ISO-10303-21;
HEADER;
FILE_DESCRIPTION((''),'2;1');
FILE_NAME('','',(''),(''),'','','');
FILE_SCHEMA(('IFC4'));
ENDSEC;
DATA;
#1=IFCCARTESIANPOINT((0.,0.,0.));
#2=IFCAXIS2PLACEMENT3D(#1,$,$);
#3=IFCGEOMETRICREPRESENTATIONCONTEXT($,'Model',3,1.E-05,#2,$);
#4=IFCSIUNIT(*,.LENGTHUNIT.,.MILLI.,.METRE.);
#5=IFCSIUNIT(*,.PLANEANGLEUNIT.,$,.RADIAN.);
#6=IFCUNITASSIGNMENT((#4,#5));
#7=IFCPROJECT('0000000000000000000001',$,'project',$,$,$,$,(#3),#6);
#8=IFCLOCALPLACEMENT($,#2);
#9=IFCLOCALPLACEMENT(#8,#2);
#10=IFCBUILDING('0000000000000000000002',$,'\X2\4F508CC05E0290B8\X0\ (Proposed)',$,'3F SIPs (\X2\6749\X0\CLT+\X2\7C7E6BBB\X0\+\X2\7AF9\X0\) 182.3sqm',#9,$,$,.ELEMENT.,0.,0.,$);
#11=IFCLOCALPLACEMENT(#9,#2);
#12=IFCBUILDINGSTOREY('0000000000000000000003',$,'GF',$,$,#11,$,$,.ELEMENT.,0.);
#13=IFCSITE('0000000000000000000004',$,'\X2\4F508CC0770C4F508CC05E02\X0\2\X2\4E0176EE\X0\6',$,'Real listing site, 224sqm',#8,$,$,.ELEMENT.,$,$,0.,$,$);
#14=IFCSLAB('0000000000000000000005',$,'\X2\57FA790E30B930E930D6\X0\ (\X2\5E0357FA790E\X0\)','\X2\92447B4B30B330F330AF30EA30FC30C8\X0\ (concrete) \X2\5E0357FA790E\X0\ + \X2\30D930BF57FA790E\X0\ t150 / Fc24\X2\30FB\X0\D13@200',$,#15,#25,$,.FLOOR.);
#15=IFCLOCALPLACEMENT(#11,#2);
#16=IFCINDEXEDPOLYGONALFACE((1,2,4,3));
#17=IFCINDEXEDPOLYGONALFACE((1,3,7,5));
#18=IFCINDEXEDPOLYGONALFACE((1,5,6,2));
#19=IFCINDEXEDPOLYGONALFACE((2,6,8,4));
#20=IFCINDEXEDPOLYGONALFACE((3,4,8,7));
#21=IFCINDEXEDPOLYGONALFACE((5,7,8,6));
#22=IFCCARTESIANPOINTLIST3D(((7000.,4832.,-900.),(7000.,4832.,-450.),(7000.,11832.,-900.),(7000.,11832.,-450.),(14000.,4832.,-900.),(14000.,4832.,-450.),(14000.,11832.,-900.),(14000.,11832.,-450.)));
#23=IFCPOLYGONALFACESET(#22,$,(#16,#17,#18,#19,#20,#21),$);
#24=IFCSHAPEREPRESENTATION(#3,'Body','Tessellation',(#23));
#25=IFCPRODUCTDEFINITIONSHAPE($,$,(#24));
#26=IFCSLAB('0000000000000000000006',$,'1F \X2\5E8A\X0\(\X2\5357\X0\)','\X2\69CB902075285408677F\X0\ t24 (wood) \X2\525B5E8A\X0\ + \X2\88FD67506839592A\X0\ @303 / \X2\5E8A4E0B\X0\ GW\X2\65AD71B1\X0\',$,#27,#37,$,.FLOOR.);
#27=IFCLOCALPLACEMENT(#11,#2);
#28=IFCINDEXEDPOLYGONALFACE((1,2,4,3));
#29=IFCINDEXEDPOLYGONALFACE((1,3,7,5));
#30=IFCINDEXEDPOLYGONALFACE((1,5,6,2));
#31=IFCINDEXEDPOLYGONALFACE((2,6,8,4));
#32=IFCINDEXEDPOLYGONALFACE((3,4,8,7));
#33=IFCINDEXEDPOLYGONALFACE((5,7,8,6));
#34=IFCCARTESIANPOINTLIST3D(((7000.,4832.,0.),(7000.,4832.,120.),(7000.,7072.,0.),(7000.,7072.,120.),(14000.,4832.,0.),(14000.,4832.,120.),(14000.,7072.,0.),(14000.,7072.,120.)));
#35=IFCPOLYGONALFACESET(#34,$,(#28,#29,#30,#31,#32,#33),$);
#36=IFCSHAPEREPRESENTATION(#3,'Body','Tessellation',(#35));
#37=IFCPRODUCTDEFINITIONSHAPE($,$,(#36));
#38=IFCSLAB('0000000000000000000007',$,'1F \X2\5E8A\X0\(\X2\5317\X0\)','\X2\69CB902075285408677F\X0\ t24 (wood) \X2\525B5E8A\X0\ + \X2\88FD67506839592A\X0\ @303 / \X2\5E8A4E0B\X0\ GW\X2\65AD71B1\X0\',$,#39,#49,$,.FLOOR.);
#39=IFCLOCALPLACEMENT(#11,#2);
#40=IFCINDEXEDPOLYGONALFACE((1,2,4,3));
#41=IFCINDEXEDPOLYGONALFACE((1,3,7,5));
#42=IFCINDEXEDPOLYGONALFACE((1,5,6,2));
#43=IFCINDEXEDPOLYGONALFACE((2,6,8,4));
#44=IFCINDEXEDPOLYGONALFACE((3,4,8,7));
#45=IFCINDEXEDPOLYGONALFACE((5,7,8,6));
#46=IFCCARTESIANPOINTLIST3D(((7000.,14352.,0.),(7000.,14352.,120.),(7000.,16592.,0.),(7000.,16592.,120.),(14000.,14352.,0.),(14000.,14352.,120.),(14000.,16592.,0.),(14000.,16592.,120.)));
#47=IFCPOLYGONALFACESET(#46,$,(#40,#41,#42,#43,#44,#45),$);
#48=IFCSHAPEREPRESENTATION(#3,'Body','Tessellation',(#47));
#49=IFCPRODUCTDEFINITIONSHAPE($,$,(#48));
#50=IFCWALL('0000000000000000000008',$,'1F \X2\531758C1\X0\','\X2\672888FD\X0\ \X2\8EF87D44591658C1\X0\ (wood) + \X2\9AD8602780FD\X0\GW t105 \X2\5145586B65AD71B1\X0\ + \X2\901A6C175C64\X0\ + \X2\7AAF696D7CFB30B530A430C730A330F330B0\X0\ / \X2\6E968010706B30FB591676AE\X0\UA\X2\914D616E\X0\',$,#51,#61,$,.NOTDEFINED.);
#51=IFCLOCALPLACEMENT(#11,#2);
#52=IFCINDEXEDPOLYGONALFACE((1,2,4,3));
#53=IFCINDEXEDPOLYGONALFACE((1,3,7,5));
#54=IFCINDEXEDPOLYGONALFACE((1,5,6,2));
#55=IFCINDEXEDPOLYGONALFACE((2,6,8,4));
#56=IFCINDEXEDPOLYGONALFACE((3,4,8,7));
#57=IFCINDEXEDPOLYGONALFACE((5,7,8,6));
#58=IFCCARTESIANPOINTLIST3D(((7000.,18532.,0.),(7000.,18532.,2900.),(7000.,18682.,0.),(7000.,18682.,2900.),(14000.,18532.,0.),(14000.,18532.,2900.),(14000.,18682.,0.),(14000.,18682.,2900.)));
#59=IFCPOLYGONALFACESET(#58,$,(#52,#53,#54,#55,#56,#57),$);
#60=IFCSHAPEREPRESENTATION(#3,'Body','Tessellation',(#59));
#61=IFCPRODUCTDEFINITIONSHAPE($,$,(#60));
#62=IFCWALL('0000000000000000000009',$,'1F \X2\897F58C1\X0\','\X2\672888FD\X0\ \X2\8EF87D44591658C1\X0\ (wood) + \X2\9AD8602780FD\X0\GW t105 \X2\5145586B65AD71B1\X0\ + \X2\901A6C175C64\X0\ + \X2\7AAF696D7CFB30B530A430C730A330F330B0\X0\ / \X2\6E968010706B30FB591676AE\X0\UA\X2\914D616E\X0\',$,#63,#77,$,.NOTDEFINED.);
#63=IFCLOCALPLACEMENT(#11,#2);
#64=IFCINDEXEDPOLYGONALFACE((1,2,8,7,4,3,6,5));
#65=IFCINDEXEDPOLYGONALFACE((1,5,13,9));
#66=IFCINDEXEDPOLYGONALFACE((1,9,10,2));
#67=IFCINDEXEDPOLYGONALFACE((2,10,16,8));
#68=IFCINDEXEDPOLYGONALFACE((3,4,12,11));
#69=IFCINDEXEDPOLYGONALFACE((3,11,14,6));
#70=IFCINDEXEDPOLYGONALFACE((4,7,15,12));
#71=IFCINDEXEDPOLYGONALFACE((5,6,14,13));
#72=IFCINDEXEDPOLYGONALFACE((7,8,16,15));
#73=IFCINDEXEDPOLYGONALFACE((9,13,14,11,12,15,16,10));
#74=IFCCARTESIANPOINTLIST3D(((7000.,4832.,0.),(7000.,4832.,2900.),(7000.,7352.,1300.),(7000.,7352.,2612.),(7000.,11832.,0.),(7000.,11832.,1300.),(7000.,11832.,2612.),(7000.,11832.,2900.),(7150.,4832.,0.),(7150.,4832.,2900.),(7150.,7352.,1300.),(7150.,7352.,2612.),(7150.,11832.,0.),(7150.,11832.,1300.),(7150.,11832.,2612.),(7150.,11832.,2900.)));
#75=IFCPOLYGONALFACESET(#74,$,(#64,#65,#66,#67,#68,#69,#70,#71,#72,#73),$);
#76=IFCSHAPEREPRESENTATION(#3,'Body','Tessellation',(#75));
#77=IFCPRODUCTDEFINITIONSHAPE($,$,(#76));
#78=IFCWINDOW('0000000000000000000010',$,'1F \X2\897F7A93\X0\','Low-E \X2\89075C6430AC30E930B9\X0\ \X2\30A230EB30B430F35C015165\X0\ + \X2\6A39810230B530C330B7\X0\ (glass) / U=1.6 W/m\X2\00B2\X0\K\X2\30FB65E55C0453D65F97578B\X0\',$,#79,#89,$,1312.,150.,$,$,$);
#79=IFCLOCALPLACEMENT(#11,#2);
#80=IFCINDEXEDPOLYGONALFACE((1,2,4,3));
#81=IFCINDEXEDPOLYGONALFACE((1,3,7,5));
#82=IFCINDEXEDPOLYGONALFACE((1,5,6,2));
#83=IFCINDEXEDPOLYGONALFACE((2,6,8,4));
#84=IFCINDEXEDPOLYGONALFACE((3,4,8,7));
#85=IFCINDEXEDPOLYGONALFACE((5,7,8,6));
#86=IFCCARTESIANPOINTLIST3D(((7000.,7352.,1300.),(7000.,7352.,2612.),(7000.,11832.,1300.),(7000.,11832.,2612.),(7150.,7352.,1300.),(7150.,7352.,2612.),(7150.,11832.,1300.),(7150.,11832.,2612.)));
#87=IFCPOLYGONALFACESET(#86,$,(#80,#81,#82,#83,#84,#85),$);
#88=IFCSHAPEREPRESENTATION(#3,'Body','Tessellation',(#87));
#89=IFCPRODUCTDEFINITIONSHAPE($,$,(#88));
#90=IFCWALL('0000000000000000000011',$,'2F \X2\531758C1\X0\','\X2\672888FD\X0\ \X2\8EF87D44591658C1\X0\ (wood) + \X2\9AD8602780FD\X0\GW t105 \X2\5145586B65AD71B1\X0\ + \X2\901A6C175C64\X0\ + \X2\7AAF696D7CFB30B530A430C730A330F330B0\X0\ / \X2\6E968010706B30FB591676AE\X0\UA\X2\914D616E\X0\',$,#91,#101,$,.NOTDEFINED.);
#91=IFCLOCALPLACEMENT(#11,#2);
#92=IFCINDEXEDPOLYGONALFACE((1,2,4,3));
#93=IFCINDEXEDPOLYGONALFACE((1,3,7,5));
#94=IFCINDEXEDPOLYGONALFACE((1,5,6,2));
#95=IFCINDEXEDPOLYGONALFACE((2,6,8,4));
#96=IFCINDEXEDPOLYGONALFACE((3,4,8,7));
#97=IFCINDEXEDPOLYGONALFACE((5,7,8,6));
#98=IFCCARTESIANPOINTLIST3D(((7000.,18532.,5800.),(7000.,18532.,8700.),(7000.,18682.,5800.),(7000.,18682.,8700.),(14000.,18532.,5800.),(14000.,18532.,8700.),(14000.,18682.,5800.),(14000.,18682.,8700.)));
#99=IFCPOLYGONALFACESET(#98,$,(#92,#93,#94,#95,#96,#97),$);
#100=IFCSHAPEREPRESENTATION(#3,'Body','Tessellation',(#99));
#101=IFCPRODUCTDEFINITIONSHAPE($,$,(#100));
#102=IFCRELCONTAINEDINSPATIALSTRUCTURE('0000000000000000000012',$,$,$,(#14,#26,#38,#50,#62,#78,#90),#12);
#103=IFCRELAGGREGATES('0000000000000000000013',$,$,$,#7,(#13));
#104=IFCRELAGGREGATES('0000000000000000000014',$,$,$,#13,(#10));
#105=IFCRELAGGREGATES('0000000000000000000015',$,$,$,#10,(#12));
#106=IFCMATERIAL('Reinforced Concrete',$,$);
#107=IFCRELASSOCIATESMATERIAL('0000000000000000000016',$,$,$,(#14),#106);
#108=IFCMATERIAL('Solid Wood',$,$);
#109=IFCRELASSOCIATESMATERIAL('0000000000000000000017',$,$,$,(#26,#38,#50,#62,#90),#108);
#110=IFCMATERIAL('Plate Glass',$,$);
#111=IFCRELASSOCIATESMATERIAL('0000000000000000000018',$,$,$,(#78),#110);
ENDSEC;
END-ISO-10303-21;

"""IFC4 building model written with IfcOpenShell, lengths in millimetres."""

from ifc_helpers import new_model, si_unit, frame, frame_2d, origin, place, context, project, spatial, rectangle, extrude, material, element, fill, save


model = new_model("IFC4")

# Units and contexts
model_context = context("Model", 3, precision=1e-05, world=origin())
ifc_project = project(units=[si_unit("LENGTHUNIT", "METRE", prefix="MILLI"), si_unit("PLANEANGLEUNIT", "RADIAN")], contexts=[model_context])

# Site, building, storey
site_placement = place(None, origin())
site = spatial("IfcSite", under=ifc_project, at=site_placement, Name="佐賀県佐賀市2丁目6", ObjectType="Real listing site, 224sqm", CompositionType="ELEMENT", RefElevation=0.0)
building_placement = place(site_placement, origin())
building = spatial("IfcBuilding", under=site, at=building_placement, Name="佐賀市邸 (Proposed)", ObjectType="3F SIPs (杉CLT+籾殻+竹) 182.3sqm", CompositionType="ELEMENT", ElevationOfRefHeight=0.0, ElevationOfTerrain=0.0)
storey_placement = place(building_placement, origin())
storey = spatial("IfcBuildingStorey", under=building, at=storey_placement, Name="GF", CompositionType="ELEMENT", Elevation=0.0)

# Slabs
ifc_material_1 = material(Name="Reinforced Concrete")
slab_1_placement = place(storey_placement, frame((3500.0, 2416.0, -450.0)))
element("IfcSlab", 1, at=slab_1_placement, inside=storey, material=ifc_material_1, Name="基礎スラブ (布基礎)", Description="鉄筋コンクリート (concrete) 布基礎 + ベタ基礎 t150 / Fc24・D13@200", PredefinedType="FLOOR", context=model_context, shape_type="SweptSolid", body=[
    extrude(rectangle(XDim=7000.0, YDim=7000.0, at=frame_2d((3500.0, 3500.0))), frame((3500.0, 2416.0, -450.0)), (0.0, 0.0, 1.0), 450.0),
])
ifc_material_2 = material(Name="Solid Wood")
slab_2_placement = place(storey_placement, frame((3500.0, 2416.0, 0.0)))
element("IfcSlab", 2, at=slab_2_placement, inside=storey, material=ifc_material_2, Name="1F 床(南)", Description="構造用合板 t24 (wood) 剛床 + 製材根太 @303 / 床下 GW断熱", PredefinedType="FLOOR", context=model_context, shape_type="SweptSolid", body=[
    extrude(rectangle(XDim=7000.0, YDim=2240.0, at=frame_2d((3500.0, 1120.0))), frame((3500.0, 2416.0, 0.0)), (0.0, 0.0, 1.0), 120.0),
])
slab_3_placement = place(storey_placement, frame((3500.0, 7176.0, 0.0)))
element("IfcSlab", 3, at=slab_3_placement, inside=storey, material=ifc_material_2, Name="1F 床(北)", Description="構造用合板 t24 (wood) 剛床 + 製材根太 @303 / 床下 GW断熱", PredefinedType="FLOOR", context=model_context, shape_type="SweptSolid", body=[
    extrude(rectangle(XDim=7000.0, YDim=2240.0, at=frame_2d((3500.0, 1120.0))), frame((3500.0, 7176.0, 0.0)), (0.0, 0.0, 1.0), 120.0),
])

# Shared definitions
ifc_material_3 = material(Name="Plate Glass")

# Wall
wall_1_placement = place(storey_placement, frame((3500.0, 9266.0, 0.0)))
element("IfcWall", 4, at=wall_1_placement, inside=storey, material=ifc_material_2, Name="1F 北壁", Description="木製 軸組外壁 (wood) + 高性能GW t105 充填断熱 + 通気層 + 窯業系サイディング / 準耐火・外皮UA配慮", PredefinedType="NOTDEFINED", context=model_context, shape_type="SweptSolid", body=[
    extrude(rectangle(XDim=7000.0, YDim=150.0, at=frame_2d((3500.0, 75.0))), frame((3500.0, 9266.0, 0.0)), (0.0, 0.0, 1.0), 2900.0),
])

# Wall, opening, window
wall_2_placement = place(storey_placement, frame((3500.0, 2416.0, 0.0)))
wall_2 = element("IfcWall", 5, at=wall_2_placement, inside=storey, material=ifc_material_2, Name="1F 西壁", Description="木製 軸組外壁 (wood) + 高性能GW t105 充填断熱 + 通気層 + 窯業系サイディング / 準耐火・外皮UA配慮", PredefinedType="NOTDEFINED", context=model_context, shape_type="SweptSolid", body=[
    extrude(rectangle(XDim=150.0, YDim=7000.0, at=frame_2d((75.0, 3500.0))), frame((3500.0, 2416.0, 0.0)), (0.0, 0.0, 1.0), 2900.0),
])
opening_1_placement = place(storey_placement, frame((3500.0, 3676.0, 650.0)))
opening_1 = element("IfcOpeningElement", 6, at=opening_1_placement, cuts=wall_2, PredefinedType="NOTDEFINED", context=model_context, shape_type="SweptSolid", body=[
    extrude(rectangle(XDim=150.0, YDim=4480.0, at=frame_2d((75.0, 2240.0))), frame((3500.0, 3676.0, 650.0)), (0.0, 0.0, 1.0), 1312.0),
])
window_1_placement = place(storey_placement, frame((3500.0, 3676.0, 650.0)))
window_1 = element("IfcWindow", 7, at=window_1_placement, inside=storey, material=ifc_material_3, Name="1F 西窓", Description="Low-E 複層ガラス アルゴン封入 + 樹脂サッシ (glass) / U=1.6 W/m²K・日射取得型", OverallHeight=1312.0, OverallWidth=150.0, context=model_context, shape_type="SweptSolid", body=[
    extrude(rectangle(XDim=150.0, YDim=4480.0, at=frame_2d((75.0, 2240.0))), frame((3500.0, 3676.0, 650.0)), (0.0, 0.0, 1.0), 1312.0),
])
fill(opening_1, window_1)

# Wall
wall_3_placement = place(storey_placement, frame((3500.0, 9266.0, 2900.0)))
element("IfcWall", 8, at=wall_3_placement, inside=storey, material=ifc_material_2, Name="2F 北壁", Description="木製 軸組外壁 (wood) + 高性能GW t105 充填断熱 + 通気層 + 窯業系サイディング / 準耐火・外皮UA配慮", PredefinedType="NOTDEFINED", context=model_context, shape_type="SweptSolid", body=[
    extrude(rectangle(XDim=7000.0, YDim=150.0, at=frame_2d((3500.0, 75.0))), frame((3500.0, 9266.0, 2900.0)), (0.0, 0.0, 1.0), 2900.0),
])

save(model, "model.ifc")
